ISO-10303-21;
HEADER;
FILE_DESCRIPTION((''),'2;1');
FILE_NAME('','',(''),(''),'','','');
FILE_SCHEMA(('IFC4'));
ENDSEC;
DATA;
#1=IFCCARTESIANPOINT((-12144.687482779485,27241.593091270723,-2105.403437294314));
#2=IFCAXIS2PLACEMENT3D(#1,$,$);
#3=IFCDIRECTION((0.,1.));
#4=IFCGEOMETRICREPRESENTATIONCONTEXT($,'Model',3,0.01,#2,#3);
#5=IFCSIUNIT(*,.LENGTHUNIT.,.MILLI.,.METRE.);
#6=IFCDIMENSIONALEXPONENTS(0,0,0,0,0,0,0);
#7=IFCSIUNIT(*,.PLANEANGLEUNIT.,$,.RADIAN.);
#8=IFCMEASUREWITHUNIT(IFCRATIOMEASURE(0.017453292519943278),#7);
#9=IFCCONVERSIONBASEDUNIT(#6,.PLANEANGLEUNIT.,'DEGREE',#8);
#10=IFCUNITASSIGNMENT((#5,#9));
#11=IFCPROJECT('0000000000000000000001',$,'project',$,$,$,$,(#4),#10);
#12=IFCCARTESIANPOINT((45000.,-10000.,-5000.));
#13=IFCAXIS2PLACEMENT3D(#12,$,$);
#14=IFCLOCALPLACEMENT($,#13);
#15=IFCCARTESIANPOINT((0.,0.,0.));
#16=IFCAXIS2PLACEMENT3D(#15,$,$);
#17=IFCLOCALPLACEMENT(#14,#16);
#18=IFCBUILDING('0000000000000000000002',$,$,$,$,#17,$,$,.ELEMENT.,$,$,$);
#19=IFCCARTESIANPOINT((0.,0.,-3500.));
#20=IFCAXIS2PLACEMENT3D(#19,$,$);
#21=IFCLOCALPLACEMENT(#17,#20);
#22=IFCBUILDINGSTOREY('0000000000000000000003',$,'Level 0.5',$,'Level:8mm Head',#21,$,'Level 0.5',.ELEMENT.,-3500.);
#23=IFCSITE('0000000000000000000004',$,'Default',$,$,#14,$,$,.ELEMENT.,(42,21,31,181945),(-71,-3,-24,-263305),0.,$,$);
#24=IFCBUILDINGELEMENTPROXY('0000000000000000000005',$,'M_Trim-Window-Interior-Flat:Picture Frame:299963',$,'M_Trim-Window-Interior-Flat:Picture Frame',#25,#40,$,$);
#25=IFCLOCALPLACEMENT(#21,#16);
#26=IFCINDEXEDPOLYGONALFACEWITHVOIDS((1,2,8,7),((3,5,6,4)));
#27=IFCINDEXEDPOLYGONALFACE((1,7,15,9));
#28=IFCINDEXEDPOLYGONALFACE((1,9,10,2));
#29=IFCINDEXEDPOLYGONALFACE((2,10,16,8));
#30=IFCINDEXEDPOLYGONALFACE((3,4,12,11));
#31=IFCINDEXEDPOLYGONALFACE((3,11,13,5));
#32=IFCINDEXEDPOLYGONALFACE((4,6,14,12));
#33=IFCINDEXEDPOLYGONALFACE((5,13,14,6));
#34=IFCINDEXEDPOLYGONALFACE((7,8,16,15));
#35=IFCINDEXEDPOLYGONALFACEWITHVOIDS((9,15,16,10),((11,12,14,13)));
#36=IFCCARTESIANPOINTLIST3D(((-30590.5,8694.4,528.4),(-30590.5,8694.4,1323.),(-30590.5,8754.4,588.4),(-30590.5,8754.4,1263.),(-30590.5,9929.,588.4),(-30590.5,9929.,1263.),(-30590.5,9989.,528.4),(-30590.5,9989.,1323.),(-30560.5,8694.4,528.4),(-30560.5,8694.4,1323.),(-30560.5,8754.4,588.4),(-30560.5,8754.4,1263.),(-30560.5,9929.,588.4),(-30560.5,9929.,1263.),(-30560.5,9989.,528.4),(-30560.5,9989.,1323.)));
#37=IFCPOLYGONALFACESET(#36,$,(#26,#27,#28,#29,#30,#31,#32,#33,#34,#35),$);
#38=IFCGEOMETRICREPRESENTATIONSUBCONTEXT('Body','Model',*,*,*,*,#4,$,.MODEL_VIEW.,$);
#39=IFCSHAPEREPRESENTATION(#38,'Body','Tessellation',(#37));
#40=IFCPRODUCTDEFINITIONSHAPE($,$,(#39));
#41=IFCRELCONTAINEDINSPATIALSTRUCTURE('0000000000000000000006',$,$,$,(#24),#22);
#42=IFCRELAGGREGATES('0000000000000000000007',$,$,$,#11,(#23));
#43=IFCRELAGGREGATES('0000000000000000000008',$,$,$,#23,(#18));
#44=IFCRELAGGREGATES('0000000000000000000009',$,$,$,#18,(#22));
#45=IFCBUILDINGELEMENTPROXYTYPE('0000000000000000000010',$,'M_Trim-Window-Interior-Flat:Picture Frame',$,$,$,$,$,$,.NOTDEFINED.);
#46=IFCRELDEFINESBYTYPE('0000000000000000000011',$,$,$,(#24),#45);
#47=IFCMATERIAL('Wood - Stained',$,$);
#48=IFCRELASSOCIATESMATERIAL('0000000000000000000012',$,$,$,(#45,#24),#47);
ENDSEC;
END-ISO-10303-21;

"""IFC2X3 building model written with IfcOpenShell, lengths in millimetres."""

from ifc_helpers import new_model, entity, si_unit, converted_unit, direction, frame, origin, place, context, subcontext, project, spatial, polyline, outline, extrude, source, transform, mapped, material, type_object, type_shapes, element, save


model = new_model("IFC2X3")

# Units and contexts
model_context = context("Model", 3, precision=0.01, world=frame((-12144.687482779485, 27241.593091270723, -2105.403437294314)), true_north=direction((0.0, 1.0)))
body_context = subcontext(model_context, "Body", "Model", "MODEL_VIEW")
ifc_project = project(units=[si_unit("LENGTHUNIT", "METRE", prefix="MILLI"), converted_unit("PLANEANGLEUNIT", "DEGREE", entity("IfcRatioMeasure", 0.017453292519943278), si_unit("PLANEANGLEUNIT", "RADIAN"), dimensions=[0, 0, 0, 0, 0, 0, 0])], contexts=[model_context])

# Site, building, storey
site_placement = place(None, frame((45000.0, -10000.0, -5000.0)))
site = spatial("IfcSite", under=ifc_project, at=site_placement, Name="Default", CompositionType="ELEMENT", RefLatitude=(42, 21, 31, 181945), RefLongitude=(-71, -3, -24, -263305), RefElevation=0.0)
building_placement = place(site_placement, origin())
building = spatial("IfcBuilding", under=site, at=building_placement, CompositionType="ELEMENT")
storey_placement = place(building_placement, frame((0.0, 0.0, -3500.0)))
storey = spatial("IfcBuildingStorey", under=building, at=storey_placement, Name="Level 0.5", ObjectType="Level:8mm Head", LongName="Level 0.5", CompositionType="ELEMENT", Elevation=-3500.0)

# Building element proxy
ifc_material_1 = material(Name="Wood - Stained")
building_element_proxy_type_1 = type_object("IfcBuildingElementProxyType", Name="M_Trim-Window-Interior-Flat:Picture Frame", PredefinedType="NOTDEFINED", material=ifc_material_1)
shared_shape_1 = source(origin(), body_context, "Body", "SweptSolid", [
    extrude(outline(polyline([(-647.3, -397.3), (647.3, -397.3), (647.3, 397.3), (-647.3, 397.3), (-647.3, -397.3)]), holes=[polyline([(-587.3, -337.3), (-587.3, 337.3), (587.3, 337.3), (587.3, -337.3), (-587.3, -337.3)])]), frame((0.0, -350.0, 0.0), z_axis=(0.0, 0.0, 1.0), x_axis=(-1.0, 0.0, 0.0)), (0.0, 0.0, 1.0), 30.0),
])
type_shapes(building_element_proxy_type_1, [shared_shape_1])
proxy_1_placement = place(storey_placement, frame((-30560.5, 9341.7, 1275.7), z_axis=(-1.0, 0.0, 0.0), x_axis=(0.0, -1.0, 0.0)))
element("IfcBuildingElementProxy", 1, at=proxy_1_placement, inside=storey, type_object=building_element_proxy_type_1, material=ifc_material_1, Name="M_Trim-Window-Interior-Flat:Picture Frame:299963", ObjectType="M_Trim-Window-Interior-Flat:Picture Frame", context=body_context, shape_type="MappedRepresentation", body=[
    mapped(shared_shape_1, transform((0.0, 0.0, 0.0), scale=1.0)),
])

save(model, "model.ifc")
